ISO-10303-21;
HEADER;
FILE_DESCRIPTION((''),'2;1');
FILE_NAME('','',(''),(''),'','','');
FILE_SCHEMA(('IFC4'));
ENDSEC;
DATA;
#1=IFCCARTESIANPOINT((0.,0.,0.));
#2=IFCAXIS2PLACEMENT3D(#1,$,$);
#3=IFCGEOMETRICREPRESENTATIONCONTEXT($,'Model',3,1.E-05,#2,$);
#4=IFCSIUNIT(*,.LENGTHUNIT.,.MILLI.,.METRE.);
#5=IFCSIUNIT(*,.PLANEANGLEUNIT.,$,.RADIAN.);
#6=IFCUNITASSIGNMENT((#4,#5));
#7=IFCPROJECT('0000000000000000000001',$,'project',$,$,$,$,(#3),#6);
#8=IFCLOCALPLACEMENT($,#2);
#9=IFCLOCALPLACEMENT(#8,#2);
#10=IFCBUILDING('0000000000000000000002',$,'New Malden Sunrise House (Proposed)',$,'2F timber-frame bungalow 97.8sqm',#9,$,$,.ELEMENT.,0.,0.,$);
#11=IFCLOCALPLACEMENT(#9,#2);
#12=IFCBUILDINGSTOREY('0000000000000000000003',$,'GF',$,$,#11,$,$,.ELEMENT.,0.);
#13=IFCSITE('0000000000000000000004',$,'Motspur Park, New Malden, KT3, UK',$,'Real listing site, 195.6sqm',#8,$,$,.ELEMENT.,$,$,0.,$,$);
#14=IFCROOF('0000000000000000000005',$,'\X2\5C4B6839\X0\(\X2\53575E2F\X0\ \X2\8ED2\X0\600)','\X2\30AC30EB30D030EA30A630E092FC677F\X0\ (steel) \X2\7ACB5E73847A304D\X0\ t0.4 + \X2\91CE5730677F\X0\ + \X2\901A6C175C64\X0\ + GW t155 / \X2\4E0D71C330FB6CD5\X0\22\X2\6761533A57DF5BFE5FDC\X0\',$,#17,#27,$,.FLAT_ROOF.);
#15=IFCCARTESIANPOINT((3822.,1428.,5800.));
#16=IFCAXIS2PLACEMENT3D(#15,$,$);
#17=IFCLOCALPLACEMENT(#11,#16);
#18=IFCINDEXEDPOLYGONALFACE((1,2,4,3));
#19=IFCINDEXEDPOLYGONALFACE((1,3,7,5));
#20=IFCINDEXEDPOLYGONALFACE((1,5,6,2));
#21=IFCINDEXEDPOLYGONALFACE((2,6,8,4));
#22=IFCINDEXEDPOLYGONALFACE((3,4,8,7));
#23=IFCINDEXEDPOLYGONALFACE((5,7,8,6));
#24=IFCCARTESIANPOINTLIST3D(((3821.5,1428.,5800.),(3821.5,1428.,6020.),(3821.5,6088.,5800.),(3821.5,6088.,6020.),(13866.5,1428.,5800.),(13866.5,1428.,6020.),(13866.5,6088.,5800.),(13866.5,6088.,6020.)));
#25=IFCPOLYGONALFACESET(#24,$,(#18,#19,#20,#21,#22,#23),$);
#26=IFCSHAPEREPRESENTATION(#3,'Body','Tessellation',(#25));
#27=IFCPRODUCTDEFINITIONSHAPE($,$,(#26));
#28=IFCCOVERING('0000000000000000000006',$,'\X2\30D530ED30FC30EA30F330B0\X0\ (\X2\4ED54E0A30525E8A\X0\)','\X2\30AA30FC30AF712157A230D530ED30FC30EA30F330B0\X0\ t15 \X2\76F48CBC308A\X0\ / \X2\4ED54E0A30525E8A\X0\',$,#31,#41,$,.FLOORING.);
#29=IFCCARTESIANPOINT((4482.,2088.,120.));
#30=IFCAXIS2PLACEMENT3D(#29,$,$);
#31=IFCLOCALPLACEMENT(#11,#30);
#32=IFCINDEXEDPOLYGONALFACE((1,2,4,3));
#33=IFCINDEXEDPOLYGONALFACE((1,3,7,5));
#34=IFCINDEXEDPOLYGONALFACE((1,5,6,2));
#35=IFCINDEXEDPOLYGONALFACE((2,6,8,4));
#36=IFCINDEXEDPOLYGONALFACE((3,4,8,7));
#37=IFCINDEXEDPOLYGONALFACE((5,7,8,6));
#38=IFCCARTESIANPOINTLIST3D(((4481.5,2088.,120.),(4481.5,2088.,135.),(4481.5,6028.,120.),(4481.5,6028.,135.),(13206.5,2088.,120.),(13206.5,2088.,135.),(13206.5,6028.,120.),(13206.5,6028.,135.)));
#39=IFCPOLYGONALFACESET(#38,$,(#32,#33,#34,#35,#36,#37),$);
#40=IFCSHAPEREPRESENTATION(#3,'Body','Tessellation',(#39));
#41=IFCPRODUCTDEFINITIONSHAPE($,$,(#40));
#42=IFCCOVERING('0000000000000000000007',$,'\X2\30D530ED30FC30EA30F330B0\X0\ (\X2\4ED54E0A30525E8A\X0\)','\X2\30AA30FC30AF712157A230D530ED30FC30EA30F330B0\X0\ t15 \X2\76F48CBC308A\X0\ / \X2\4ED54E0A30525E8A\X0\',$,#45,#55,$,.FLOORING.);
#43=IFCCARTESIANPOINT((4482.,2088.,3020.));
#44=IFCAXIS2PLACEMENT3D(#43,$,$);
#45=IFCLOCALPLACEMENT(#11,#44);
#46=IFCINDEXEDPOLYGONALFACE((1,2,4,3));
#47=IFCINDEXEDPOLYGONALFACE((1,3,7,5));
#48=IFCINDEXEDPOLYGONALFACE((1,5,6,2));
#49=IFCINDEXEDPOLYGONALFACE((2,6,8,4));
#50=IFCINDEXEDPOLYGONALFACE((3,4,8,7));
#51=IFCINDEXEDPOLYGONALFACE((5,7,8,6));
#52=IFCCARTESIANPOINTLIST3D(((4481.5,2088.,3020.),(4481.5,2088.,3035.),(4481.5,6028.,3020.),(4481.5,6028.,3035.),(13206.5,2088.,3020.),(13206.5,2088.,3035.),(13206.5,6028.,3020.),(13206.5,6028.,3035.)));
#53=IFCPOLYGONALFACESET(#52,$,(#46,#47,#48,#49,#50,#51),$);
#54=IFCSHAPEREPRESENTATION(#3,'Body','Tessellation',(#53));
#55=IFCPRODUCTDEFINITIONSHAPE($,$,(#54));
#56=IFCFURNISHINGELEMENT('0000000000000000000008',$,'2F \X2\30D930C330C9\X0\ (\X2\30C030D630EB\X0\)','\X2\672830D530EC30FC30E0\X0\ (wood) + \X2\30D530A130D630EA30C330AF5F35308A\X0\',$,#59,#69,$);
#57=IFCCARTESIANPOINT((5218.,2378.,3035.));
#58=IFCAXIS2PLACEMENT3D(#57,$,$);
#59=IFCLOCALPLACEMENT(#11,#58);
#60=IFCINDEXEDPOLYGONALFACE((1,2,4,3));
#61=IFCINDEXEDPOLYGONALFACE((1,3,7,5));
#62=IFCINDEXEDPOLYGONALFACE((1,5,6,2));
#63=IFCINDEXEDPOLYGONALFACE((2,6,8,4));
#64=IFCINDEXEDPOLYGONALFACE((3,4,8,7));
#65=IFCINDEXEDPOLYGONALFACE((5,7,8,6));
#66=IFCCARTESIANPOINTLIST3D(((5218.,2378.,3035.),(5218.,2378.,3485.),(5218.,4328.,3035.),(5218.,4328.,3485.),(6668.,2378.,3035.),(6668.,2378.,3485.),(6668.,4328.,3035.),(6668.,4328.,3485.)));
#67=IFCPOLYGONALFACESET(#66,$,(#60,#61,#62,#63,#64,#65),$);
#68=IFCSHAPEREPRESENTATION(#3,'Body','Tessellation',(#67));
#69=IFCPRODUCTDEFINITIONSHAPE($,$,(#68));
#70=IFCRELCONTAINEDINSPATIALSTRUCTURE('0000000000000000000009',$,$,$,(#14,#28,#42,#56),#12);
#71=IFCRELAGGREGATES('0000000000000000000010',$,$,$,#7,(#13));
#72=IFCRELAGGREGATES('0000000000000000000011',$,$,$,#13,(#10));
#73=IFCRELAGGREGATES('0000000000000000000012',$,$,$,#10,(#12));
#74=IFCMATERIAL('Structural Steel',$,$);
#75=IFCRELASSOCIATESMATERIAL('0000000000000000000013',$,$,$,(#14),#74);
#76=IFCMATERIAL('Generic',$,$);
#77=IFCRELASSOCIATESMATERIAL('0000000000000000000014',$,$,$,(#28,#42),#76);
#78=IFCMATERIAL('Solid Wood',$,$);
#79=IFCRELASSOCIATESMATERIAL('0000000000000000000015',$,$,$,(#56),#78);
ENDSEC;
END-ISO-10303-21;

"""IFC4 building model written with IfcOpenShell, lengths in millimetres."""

from ifc_helpers import new_model, si_unit, frame, frame_2d, origin, place, context, project, spatial, rectangle, extrude, material, element, save


model = new_model("IFC4")

# Units and contexts
model_context = context("Model", 3, precision=1e-05, world=origin())
ifc_project = project(units=[si_unit("LENGTHUNIT", "METRE", prefix="MILLI"), si_unit("PLANEANGLEUNIT", "RADIAN")], contexts=[model_context])

# Site, building, storey
site_placement = place(None, origin())
site = spatial("IfcSite", under=ifc_project, at=site_placement, Name="Motspur Park, New Malden, KT3, UK", ObjectType="Real listing site, 195.6sqm", CompositionType="ELEMENT", RefElevation=0.0)
building_placement = place(site_placement, origin())
building = spatial("IfcBuilding", under=site, at=building_placement, Name="New Malden Sunrise House (Proposed)", ObjectType="2F timber-frame bungalow 97.8sqm", CompositionType="ELEMENT", ElevationOfRefHeight=0.0, ElevationOfTerrain=0.0)
storey_placement = place(building_placement, origin())
storey = spatial("IfcBuildingStorey", under=building, at=storey_placement, Name="GF", CompositionType="ELEMENT", Elevation=0.0)

# Shared definitions
ifc_material_1 = material(Name="Solid Wood")

# Roof
ifc_material_2 = material(Name="Structural Steel")
for number, where, name in (
    (1, (3822.0, 1428.0, 5800.0), "屋根(南帯 軒600)"),
):
    element("IfcRoof", number, at=place(storey_placement, frame(where)), inside=storey, material=ifc_material_2, Name=name, Description="ガルバリウム鋼板 (steel) 立平葺き t0.4 + 野地板 + 通気層 + GW t155 / 不燃・法22条区域対応", PredefinedType="FLAT_ROOF", context=model_context, shape_type="SweptSolid", body=[
        extrude(rectangle(XDim=10045.0, YDim=4660.0, at=frame_2d((5022.0, 2330.0))), frame((3822.0, 1428.0, 5800.0)), (0.0, 0.0, 1.0), 220.0),
    ])

# Coverings
ifc_material_3 = material(Name="Generic")
covering_1_placement = place(storey_placement, frame((4482.0, 2088.0, 120.0)))
element("IfcCovering", 2, at=covering_1_placement, inside=storey, material=ifc_material_3, Name="フローリング (仕上げ床)", Description="オーク無垢フローリング t15 直貼り / 仕上げ床", PredefinedType="FLOORING", context=model_context, shape_type="SweptSolid", body=[
    extrude(rectangle(XDim=8725.0, YDim=3940.0, at=frame_2d((4362.0, 1970.0))), frame((4482.0, 2088.0, 120.0)), (0.0, 0.0, 1.0), 15.0),
])
covering_2_placement = place(storey_placement, frame((4482.0, 2088.0, 3020.0)))
element("IfcCovering", 3, at=covering_2_placement, inside=storey, material=ifc_material_3, Name="フローリング (仕上げ床)", Description="オーク無垢フローリング t15 直貼り / 仕上げ床", PredefinedType="FLOORING", context=model_context, shape_type="SweptSolid", body=[
    extrude(rectangle(XDim=8725.0, YDim=3940.0, at=frame_2d((4362.0, 1970.0))), frame((4482.0, 2088.0, 3020.0)), (0.0, 0.0, 1.0), 15.0),
])

# Furnishing element
furnishing_placement = place(storey_placement, frame((5218.0, 2378.0, 3035.0)))
element("IfcFurnishingElement", 4, at=furnishing_placement, inside=storey, material=ifc_material_1, Name="2F ベッド (ダブル)", Description="木フレーム (wood) + ファブリック張り", context=model_context, shape_type="SweptSolid", body=[
    extrude(rectangle(XDim=1450.0, YDim=1950.0, at=frame_2d((725.0, 975.0))), frame((5218.0, 2378.0, 3035.0)), (0.0, 0.0, 1.0), 450.0),
])

save(model, "model.ifc")
